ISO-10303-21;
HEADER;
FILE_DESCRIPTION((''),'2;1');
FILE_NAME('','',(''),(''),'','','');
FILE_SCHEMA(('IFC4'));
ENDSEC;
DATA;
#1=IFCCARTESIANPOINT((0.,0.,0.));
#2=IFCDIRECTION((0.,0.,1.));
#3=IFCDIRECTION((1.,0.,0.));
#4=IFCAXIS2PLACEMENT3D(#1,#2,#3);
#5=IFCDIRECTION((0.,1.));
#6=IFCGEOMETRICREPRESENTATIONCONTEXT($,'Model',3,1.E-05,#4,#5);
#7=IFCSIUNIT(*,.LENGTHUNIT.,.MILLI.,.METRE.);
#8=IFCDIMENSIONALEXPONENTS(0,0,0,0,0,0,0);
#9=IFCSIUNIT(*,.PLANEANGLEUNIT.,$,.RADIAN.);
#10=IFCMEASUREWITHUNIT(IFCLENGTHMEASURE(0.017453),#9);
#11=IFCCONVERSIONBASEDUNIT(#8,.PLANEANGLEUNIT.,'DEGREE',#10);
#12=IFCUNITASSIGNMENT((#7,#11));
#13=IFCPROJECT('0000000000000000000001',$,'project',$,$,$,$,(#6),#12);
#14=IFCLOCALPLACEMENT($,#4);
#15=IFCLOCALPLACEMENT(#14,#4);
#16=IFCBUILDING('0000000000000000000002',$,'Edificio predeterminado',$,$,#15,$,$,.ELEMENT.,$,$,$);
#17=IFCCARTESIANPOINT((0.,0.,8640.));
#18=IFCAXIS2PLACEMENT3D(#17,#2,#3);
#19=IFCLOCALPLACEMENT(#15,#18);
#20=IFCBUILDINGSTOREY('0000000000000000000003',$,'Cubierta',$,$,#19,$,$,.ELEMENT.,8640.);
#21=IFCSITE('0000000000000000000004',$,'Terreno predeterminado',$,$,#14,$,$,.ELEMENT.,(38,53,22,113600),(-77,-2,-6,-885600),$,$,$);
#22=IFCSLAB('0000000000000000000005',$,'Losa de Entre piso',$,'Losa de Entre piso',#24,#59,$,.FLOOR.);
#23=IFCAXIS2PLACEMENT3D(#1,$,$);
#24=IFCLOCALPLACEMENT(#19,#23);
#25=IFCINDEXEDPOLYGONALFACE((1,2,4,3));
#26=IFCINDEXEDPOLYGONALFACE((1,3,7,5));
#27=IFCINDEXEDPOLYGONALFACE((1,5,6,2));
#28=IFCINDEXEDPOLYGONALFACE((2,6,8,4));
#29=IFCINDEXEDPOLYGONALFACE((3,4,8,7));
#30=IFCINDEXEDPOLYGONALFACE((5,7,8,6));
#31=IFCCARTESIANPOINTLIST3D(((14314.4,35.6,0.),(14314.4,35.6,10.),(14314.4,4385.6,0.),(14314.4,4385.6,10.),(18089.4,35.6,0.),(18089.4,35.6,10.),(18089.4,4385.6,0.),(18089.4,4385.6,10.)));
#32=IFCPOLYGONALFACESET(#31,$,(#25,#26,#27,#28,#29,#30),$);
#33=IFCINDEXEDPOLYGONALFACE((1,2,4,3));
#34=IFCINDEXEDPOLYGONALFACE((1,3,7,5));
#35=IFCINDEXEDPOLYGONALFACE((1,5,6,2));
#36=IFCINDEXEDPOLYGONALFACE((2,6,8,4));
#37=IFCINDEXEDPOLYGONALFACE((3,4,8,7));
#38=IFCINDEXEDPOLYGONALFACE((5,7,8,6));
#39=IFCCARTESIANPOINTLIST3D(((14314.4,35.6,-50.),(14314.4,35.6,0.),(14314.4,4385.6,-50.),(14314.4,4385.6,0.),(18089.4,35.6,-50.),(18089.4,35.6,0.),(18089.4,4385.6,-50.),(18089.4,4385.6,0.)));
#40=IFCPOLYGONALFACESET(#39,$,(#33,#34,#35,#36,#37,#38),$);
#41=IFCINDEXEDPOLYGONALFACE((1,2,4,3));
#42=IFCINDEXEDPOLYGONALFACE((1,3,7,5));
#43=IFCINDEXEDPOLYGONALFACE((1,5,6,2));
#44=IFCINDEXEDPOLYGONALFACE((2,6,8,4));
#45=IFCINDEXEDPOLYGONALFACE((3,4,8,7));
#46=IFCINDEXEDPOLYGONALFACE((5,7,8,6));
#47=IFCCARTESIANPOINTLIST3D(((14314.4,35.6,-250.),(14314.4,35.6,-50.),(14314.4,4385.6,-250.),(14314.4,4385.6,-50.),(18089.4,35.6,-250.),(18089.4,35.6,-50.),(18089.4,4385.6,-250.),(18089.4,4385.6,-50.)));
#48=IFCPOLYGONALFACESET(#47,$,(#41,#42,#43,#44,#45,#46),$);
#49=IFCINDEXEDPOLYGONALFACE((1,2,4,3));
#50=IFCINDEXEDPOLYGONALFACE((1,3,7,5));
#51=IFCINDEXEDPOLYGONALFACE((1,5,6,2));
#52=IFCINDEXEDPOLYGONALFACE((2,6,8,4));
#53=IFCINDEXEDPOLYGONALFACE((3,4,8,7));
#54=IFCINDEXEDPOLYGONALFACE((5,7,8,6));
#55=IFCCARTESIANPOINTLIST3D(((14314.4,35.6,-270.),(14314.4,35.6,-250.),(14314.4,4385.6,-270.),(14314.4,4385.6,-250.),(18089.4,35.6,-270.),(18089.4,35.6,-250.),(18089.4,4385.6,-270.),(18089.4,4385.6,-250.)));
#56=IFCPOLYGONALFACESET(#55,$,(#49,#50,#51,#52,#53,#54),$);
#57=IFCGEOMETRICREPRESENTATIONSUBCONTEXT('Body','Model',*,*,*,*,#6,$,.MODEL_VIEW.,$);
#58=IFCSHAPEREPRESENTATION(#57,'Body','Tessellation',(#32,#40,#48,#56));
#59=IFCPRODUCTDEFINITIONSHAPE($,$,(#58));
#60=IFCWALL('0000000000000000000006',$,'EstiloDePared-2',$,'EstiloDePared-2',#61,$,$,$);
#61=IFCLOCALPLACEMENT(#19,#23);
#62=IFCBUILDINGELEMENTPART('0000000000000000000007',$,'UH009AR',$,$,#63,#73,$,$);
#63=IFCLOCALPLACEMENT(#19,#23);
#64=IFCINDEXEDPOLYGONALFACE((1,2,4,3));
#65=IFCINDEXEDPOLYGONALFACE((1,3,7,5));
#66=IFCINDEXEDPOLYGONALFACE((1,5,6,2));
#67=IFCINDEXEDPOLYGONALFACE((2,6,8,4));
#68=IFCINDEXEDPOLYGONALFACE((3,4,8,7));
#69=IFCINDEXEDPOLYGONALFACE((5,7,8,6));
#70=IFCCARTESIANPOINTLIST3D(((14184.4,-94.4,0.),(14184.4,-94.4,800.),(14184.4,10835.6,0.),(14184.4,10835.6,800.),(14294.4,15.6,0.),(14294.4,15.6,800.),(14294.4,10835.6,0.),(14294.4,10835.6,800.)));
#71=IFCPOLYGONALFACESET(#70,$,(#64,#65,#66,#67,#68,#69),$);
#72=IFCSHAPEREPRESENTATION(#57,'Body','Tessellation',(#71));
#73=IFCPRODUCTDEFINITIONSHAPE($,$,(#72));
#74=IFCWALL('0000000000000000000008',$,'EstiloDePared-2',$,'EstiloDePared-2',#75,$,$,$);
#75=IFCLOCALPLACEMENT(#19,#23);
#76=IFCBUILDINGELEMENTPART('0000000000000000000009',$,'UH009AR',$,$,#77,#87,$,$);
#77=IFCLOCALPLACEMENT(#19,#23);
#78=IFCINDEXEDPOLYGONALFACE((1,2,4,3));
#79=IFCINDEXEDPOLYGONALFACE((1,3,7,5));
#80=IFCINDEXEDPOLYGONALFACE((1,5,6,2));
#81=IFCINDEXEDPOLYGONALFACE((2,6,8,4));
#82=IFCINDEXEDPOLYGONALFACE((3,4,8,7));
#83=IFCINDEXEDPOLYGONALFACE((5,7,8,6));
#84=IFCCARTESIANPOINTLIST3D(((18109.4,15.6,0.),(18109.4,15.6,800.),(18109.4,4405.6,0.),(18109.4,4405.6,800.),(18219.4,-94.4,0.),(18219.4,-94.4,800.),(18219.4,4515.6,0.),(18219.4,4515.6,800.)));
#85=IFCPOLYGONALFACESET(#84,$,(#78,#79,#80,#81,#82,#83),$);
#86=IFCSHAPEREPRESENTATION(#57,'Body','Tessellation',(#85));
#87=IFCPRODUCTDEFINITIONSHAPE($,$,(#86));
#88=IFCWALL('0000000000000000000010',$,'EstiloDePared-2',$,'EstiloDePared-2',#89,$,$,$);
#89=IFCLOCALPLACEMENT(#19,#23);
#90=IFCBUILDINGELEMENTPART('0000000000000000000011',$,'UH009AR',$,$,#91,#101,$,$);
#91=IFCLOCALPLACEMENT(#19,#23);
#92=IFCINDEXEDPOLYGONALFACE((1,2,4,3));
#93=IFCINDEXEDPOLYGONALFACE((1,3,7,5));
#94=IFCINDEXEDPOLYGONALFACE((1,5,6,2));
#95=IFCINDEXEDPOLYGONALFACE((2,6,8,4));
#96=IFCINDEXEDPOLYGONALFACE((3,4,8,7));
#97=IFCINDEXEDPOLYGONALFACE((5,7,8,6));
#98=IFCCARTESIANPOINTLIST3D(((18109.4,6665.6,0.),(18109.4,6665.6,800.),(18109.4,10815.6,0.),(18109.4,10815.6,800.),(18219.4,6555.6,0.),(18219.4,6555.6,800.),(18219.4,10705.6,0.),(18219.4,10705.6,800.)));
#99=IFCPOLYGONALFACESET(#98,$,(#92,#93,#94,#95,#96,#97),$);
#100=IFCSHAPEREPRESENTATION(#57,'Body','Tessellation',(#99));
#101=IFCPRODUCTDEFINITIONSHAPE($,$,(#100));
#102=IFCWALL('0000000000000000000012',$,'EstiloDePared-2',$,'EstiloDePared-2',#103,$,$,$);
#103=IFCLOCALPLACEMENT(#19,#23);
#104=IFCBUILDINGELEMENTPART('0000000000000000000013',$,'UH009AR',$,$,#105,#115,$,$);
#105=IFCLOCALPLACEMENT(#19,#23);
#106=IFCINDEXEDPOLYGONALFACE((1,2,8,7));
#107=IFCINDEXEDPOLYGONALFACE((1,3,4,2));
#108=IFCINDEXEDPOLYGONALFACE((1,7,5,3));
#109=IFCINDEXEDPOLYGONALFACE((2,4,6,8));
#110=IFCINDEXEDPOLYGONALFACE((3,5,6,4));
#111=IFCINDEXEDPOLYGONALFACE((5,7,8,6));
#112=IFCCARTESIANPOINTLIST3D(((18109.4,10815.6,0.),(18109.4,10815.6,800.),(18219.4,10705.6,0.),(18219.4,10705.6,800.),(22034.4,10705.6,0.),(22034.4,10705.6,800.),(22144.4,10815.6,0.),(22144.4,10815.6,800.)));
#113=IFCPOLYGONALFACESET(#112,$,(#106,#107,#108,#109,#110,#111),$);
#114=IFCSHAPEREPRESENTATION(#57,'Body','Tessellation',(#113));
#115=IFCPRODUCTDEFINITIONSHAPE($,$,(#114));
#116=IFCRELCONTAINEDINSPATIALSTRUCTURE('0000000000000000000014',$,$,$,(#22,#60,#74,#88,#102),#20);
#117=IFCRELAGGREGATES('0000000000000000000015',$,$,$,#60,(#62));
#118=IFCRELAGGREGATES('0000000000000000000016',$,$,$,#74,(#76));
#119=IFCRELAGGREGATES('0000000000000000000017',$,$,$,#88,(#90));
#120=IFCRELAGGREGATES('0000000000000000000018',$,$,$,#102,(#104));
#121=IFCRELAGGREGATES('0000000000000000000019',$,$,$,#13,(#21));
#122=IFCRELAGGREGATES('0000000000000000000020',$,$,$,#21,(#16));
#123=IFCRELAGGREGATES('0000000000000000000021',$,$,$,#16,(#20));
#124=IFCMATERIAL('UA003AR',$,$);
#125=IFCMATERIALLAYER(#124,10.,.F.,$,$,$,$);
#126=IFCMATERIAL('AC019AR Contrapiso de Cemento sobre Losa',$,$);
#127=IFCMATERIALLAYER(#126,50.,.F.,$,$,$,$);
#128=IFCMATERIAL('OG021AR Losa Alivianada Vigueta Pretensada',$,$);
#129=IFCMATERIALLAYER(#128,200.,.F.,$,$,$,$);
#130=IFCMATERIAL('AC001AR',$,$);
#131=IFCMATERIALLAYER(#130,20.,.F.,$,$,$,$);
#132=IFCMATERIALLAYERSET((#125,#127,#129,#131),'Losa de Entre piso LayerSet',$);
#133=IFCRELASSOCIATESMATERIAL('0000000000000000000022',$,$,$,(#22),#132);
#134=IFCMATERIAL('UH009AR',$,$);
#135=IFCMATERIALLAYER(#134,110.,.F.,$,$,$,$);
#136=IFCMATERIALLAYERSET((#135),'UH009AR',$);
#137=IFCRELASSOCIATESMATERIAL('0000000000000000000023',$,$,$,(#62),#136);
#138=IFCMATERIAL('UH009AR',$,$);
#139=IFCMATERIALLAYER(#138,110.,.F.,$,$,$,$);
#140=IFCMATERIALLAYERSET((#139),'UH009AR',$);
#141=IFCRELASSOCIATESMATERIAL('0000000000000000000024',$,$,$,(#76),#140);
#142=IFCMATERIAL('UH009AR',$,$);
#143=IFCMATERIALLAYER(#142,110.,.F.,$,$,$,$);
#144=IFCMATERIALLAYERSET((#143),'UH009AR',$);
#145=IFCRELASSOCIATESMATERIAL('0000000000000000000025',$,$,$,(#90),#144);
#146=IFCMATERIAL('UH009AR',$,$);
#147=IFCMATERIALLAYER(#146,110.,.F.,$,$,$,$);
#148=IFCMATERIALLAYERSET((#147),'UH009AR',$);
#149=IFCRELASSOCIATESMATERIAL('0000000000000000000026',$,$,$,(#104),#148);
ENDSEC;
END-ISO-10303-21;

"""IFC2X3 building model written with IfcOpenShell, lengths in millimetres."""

from ifc_helpers import new_model, entity, si_unit, converted_unit, direction, frame, origin_with_axes, place, context, subcontext, project, spatial, polyline, outline, extrude, material, layer, layer_set, layer_usage, element, aggregate, save


model = new_model("IFC2X3")

# Units and contexts
model_context = context("Model", 3, precision=1e-05, world=origin_with_axes(), true_north=direction((0.0, 1.0)))
body_context = subcontext(model_context, "Body", "Model", "MODEL_VIEW")
ifc_project = project(units=[si_unit("LENGTHUNIT", "METRE", prefix="MILLI"), converted_unit("PLANEANGLEUNIT", "DEGREE", entity("IfcLengthMeasure", 0.017453), si_unit("PLANEANGLEUNIT", "RADIAN"), dimensions=[0, 0, 0, 0, 0, 0, 0])], contexts=[model_context])

# Site, building, storey
site_placement = place(None, origin_with_axes())
site = spatial("IfcSite", under=ifc_project, at=site_placement, Name="Terreno predeterminado", CompositionType="ELEMENT", RefLatitude=(38, 53, 22, 113600), RefLongitude=(-77, -2, -6, -885600))
building_placement = place(site_placement, origin_with_axes())
building = spatial("IfcBuilding", under=site, at=building_placement, Name="Edificio predeterminado", CompositionType="ELEMENT")
storey_placement = place(building_placement, frame((0.0, 0.0, 8640.0), z_axis=(0.0, 0.0, 1.0), x_axis=(1.0, 0.0, 0.0)))
storey = spatial("IfcBuildingStorey", under=building, at=storey_placement, Name="Cubierta", CompositionType="ELEMENT", Elevation=8640.0)

# Slab
ifc_material_1 = material(Name="UA003AR")
ifc_layer_1 = layer(ifc_material_1, 10.0, ventilated=False)
ifc_material_2 = material(Name="AC019AR Contrapiso de Cemento sobre Losa")
ifc_layer_2 = layer(ifc_material_2, 50.0, ventilated=False)
ifc_material_3 = material(Name="OG021AR Losa Alivianada Vigueta Pretensada")
ifc_layer_3 = layer(ifc_material_3, 200.0, ventilated=False)
ifc_material_4 = material(Name="AC001AR")
ifc_layer_4 = layer(ifc_material_4, 20.0, ventilated=False)
ifc_layer_set_1 = layer_set([ifc_layer_1, ifc_layer_2, ifc_layer_3, ifc_layer_4], Name="Losa de Entre piso LayerSet")
ifc_layer_usage_1 = layer_usage(ifc_layer_set_1, "AXIS3", "NEGATIVE", 0.0)
slab_1_placement = place(storey_placement, frame((0.0, 0.0, -8640.0), z_axis=(0.0, 0.0, 1.0), x_axis=(1.0, 0.0, 0.0)))
element("IfcSlab", 1, at=slab_1_placement, inside=storey, material=ifc_layer_usage_1, Name="Losa de Entre piso", ObjectType="Losa de Entre piso", PredefinedType="FLOOR", context=body_context, shape_type="SweptSolid", body=[
    extrude(outline(polyline([(0.0, 4350.0), (3775.0, 4350.0), (3775.0, 0.0), (0.0, 0.0), (0.0, 4350.0)])), frame((18089.4, 35.6, 8640.0), z_axis=(0.0, 0.0, -1.0), x_axis=(-1.0, 0.0, 0.0)), (0.0, 0.0, -1.0), 10.0),
    extrude(outline(polyline([(0.0, 4350.0), (3775.0, 4350.0), (3775.0, 0.0), (0.0, 0.0), (0.0, 4350.0)])), frame((18089.4, 35.6, 8590.0), z_axis=(0.0, 0.0, -1.0), x_axis=(-1.0, 0.0, 0.0)), (0.0, 0.0, -1.0), 50.0),
    extrude(outline(polyline([(0.0, 4350.0), (3775.0, 4350.0), (3775.0, 0.0), (0.0, 0.0), (0.0, 4350.0)])), frame((18089.4, 35.6, 8390.0), z_axis=(0.0, 0.0, -1.0), x_axis=(-1.0, 0.0, 0.0)), (0.0, 0.0, -1.0), 200.0),
    extrude(outline(polyline([(0.0, 4350.0), (3775.0, 4350.0), (3775.0, 0.0), (0.0, 0.0), (0.0, 4350.0)])), frame((18089.4, 35.6, 8370.0), z_axis=(0.0, 0.0, -1.0), x_axis=(-1.0, 0.0, 0.0)), (0.0, 0.0, -1.0), 20.0),
])

# Walls, building element parts
wall_1_placement = place(storey_placement, frame((14239.4, -39.4, 0.0), z_axis=(0.0, 0.0, 1.0), x_axis=(0.0, 1.0, 0.0)))
wall_1 = element("IfcWall", 2, at=wall_1_placement, inside=storey, Name="EstiloDePared-2", ObjectType="EstiloDePared-2")
ifc_material_5 = material(Name="UH009AR")
ifc_layer_5 = layer(ifc_material_5, 110.0, ventilated=False)
ifc_layer_set_2 = layer_set([ifc_layer_5], Name="UH009AR")
ifc_layer_usage_2 = layer_usage(ifc_layer_set_2, "AXIS2", "NEGATIVE", -55.0)
building_element_part_1_placement = place(wall_1_placement, origin_with_axes())
building_element_part_1 = element("IfcBuildingElementPart", 3, at=building_element_part_1_placement, material=ifc_layer_usage_2, Name="UH009AR", context=body_context, shape_type="SweptSolid", body=[
    extrude(outline(polyline([(10875.0, 55.0), (10875.0, -55.0), (55.0, -55.0), (-55.0, 55.0), (10875.0, 55.0)])), origin_with_axes(), (0.0, 0.0, 1.0), 800.0),
])
aggregate(wall_1, [building_element_part_1])
wall_2_placement = place(storey_placement, frame((18164.4, -39.4, 0.0), z_axis=(0.0, 0.0, 1.0), x_axis=(0.0, 1.0, 0.0)))
wall_2 = element("IfcWall", 4, at=wall_2_placement, inside=storey, Name="EstiloDePared-2", ObjectType="EstiloDePared-2")
ifc_material_6 = material(Name="UH009AR")
ifc_layer_6 = layer(ifc_material_6, 110.0, ventilated=False)
ifc_layer_set_3 = layer_set([ifc_layer_6], Name="UH009AR")
ifc_layer_usage_3 = layer_usage(ifc_layer_set_3, "AXIS2", "NEGATIVE", -55.0)
building_element_part_2_placement = place(wall_2_placement, origin_with_axes())
building_element_part_2 = element("IfcBuildingElementPart", 5, at=building_element_part_2_placement, material=ifc_layer_usage_3, Name="UH009AR", context=body_context, shape_type="SweptSolid", body=[
    extrude(outline(polyline([(4445.0, 55.0), (4555.0, -55.0), (-55.0, -55.0), (55.0, 55.0), (4445.0, 55.0)])), origin_with_axes(), (0.0, 0.0, 1.0), 800.0),
])
aggregate(wall_2, [building_element_part_2])
wall_3_placement = place(storey_placement, frame((18164.4, 6610.6, 0.0), z_axis=(0.0, 0.0, 1.0), x_axis=(0.0, 1.0, 0.0)))
wall_3 = element("IfcWall", 6, at=wall_3_placement, inside=storey, Name="EstiloDePared-2", ObjectType="EstiloDePared-2")
ifc_material_7 = material(Name="UH009AR")
ifc_layer_7 = layer(ifc_material_7, 110.0, ventilated=False)
ifc_layer_set_4 = layer_set([ifc_layer_7], Name="UH009AR")
ifc_layer_usage_4 = layer_usage(ifc_layer_set_4, "AXIS2", "NEGATIVE", -55.0)
building_element_part_3_placement = place(wall_3_placement, origin_with_axes())
building_element_part_3 = element("IfcBuildingElementPart", 7, at=building_element_part_3_placement, material=ifc_layer_usage_4, Name="UH009AR", context=body_context, shape_type="SweptSolid", body=[
    extrude(outline(polyline([(4205.0, 55.0), (4095.0, -55.0), (-55.0, -55.0), (55.0, 55.0), (4205.0, 55.0)])), origin_with_axes(), (0.0, 0.0, 1.0), 800.0),
])
aggregate(wall_3, [building_element_part_3])
wall_4_placement = place(storey_placement, frame((18164.4, 10760.6, 0.0), z_axis=(0.0, 0.0, 1.0), x_axis=(1.0, 0.0, 0.0)))
wall_4 = element("IfcWall", 8, at=wall_4_placement, inside=storey, Name="EstiloDePared-2", ObjectType="EstiloDePared-2")
ifc_material_8 = material(Name="UH009AR")
ifc_layer_8 = layer(ifc_material_8, 110.0, ventilated=False)
ifc_layer_set_5 = layer_set([ifc_layer_8], Name="UH009AR")
ifc_layer_usage_5 = layer_usage(ifc_layer_set_5, "AXIS2", "NEGATIVE", -55.0)
building_element_part_4_placement = place(wall_4_placement, origin_with_axes())
building_element_part_4 = element("IfcBuildingElementPart", 9, at=building_element_part_4_placement, material=ifc_layer_usage_5, Name="UH009AR", context=body_context, shape_type="SweptSolid", body=[
    extrude(outline(polyline([(3980.0, 55.0), (3870.0, -55.0), (55.0, -55.0), (-55.0, 55.0), (3980.0, 55.0)])), origin_with_axes(), (0.0, 0.0, 1.0), 800.0),
])
aggregate(wall_4, [building_element_part_4])

save(model, "model.ifc")
